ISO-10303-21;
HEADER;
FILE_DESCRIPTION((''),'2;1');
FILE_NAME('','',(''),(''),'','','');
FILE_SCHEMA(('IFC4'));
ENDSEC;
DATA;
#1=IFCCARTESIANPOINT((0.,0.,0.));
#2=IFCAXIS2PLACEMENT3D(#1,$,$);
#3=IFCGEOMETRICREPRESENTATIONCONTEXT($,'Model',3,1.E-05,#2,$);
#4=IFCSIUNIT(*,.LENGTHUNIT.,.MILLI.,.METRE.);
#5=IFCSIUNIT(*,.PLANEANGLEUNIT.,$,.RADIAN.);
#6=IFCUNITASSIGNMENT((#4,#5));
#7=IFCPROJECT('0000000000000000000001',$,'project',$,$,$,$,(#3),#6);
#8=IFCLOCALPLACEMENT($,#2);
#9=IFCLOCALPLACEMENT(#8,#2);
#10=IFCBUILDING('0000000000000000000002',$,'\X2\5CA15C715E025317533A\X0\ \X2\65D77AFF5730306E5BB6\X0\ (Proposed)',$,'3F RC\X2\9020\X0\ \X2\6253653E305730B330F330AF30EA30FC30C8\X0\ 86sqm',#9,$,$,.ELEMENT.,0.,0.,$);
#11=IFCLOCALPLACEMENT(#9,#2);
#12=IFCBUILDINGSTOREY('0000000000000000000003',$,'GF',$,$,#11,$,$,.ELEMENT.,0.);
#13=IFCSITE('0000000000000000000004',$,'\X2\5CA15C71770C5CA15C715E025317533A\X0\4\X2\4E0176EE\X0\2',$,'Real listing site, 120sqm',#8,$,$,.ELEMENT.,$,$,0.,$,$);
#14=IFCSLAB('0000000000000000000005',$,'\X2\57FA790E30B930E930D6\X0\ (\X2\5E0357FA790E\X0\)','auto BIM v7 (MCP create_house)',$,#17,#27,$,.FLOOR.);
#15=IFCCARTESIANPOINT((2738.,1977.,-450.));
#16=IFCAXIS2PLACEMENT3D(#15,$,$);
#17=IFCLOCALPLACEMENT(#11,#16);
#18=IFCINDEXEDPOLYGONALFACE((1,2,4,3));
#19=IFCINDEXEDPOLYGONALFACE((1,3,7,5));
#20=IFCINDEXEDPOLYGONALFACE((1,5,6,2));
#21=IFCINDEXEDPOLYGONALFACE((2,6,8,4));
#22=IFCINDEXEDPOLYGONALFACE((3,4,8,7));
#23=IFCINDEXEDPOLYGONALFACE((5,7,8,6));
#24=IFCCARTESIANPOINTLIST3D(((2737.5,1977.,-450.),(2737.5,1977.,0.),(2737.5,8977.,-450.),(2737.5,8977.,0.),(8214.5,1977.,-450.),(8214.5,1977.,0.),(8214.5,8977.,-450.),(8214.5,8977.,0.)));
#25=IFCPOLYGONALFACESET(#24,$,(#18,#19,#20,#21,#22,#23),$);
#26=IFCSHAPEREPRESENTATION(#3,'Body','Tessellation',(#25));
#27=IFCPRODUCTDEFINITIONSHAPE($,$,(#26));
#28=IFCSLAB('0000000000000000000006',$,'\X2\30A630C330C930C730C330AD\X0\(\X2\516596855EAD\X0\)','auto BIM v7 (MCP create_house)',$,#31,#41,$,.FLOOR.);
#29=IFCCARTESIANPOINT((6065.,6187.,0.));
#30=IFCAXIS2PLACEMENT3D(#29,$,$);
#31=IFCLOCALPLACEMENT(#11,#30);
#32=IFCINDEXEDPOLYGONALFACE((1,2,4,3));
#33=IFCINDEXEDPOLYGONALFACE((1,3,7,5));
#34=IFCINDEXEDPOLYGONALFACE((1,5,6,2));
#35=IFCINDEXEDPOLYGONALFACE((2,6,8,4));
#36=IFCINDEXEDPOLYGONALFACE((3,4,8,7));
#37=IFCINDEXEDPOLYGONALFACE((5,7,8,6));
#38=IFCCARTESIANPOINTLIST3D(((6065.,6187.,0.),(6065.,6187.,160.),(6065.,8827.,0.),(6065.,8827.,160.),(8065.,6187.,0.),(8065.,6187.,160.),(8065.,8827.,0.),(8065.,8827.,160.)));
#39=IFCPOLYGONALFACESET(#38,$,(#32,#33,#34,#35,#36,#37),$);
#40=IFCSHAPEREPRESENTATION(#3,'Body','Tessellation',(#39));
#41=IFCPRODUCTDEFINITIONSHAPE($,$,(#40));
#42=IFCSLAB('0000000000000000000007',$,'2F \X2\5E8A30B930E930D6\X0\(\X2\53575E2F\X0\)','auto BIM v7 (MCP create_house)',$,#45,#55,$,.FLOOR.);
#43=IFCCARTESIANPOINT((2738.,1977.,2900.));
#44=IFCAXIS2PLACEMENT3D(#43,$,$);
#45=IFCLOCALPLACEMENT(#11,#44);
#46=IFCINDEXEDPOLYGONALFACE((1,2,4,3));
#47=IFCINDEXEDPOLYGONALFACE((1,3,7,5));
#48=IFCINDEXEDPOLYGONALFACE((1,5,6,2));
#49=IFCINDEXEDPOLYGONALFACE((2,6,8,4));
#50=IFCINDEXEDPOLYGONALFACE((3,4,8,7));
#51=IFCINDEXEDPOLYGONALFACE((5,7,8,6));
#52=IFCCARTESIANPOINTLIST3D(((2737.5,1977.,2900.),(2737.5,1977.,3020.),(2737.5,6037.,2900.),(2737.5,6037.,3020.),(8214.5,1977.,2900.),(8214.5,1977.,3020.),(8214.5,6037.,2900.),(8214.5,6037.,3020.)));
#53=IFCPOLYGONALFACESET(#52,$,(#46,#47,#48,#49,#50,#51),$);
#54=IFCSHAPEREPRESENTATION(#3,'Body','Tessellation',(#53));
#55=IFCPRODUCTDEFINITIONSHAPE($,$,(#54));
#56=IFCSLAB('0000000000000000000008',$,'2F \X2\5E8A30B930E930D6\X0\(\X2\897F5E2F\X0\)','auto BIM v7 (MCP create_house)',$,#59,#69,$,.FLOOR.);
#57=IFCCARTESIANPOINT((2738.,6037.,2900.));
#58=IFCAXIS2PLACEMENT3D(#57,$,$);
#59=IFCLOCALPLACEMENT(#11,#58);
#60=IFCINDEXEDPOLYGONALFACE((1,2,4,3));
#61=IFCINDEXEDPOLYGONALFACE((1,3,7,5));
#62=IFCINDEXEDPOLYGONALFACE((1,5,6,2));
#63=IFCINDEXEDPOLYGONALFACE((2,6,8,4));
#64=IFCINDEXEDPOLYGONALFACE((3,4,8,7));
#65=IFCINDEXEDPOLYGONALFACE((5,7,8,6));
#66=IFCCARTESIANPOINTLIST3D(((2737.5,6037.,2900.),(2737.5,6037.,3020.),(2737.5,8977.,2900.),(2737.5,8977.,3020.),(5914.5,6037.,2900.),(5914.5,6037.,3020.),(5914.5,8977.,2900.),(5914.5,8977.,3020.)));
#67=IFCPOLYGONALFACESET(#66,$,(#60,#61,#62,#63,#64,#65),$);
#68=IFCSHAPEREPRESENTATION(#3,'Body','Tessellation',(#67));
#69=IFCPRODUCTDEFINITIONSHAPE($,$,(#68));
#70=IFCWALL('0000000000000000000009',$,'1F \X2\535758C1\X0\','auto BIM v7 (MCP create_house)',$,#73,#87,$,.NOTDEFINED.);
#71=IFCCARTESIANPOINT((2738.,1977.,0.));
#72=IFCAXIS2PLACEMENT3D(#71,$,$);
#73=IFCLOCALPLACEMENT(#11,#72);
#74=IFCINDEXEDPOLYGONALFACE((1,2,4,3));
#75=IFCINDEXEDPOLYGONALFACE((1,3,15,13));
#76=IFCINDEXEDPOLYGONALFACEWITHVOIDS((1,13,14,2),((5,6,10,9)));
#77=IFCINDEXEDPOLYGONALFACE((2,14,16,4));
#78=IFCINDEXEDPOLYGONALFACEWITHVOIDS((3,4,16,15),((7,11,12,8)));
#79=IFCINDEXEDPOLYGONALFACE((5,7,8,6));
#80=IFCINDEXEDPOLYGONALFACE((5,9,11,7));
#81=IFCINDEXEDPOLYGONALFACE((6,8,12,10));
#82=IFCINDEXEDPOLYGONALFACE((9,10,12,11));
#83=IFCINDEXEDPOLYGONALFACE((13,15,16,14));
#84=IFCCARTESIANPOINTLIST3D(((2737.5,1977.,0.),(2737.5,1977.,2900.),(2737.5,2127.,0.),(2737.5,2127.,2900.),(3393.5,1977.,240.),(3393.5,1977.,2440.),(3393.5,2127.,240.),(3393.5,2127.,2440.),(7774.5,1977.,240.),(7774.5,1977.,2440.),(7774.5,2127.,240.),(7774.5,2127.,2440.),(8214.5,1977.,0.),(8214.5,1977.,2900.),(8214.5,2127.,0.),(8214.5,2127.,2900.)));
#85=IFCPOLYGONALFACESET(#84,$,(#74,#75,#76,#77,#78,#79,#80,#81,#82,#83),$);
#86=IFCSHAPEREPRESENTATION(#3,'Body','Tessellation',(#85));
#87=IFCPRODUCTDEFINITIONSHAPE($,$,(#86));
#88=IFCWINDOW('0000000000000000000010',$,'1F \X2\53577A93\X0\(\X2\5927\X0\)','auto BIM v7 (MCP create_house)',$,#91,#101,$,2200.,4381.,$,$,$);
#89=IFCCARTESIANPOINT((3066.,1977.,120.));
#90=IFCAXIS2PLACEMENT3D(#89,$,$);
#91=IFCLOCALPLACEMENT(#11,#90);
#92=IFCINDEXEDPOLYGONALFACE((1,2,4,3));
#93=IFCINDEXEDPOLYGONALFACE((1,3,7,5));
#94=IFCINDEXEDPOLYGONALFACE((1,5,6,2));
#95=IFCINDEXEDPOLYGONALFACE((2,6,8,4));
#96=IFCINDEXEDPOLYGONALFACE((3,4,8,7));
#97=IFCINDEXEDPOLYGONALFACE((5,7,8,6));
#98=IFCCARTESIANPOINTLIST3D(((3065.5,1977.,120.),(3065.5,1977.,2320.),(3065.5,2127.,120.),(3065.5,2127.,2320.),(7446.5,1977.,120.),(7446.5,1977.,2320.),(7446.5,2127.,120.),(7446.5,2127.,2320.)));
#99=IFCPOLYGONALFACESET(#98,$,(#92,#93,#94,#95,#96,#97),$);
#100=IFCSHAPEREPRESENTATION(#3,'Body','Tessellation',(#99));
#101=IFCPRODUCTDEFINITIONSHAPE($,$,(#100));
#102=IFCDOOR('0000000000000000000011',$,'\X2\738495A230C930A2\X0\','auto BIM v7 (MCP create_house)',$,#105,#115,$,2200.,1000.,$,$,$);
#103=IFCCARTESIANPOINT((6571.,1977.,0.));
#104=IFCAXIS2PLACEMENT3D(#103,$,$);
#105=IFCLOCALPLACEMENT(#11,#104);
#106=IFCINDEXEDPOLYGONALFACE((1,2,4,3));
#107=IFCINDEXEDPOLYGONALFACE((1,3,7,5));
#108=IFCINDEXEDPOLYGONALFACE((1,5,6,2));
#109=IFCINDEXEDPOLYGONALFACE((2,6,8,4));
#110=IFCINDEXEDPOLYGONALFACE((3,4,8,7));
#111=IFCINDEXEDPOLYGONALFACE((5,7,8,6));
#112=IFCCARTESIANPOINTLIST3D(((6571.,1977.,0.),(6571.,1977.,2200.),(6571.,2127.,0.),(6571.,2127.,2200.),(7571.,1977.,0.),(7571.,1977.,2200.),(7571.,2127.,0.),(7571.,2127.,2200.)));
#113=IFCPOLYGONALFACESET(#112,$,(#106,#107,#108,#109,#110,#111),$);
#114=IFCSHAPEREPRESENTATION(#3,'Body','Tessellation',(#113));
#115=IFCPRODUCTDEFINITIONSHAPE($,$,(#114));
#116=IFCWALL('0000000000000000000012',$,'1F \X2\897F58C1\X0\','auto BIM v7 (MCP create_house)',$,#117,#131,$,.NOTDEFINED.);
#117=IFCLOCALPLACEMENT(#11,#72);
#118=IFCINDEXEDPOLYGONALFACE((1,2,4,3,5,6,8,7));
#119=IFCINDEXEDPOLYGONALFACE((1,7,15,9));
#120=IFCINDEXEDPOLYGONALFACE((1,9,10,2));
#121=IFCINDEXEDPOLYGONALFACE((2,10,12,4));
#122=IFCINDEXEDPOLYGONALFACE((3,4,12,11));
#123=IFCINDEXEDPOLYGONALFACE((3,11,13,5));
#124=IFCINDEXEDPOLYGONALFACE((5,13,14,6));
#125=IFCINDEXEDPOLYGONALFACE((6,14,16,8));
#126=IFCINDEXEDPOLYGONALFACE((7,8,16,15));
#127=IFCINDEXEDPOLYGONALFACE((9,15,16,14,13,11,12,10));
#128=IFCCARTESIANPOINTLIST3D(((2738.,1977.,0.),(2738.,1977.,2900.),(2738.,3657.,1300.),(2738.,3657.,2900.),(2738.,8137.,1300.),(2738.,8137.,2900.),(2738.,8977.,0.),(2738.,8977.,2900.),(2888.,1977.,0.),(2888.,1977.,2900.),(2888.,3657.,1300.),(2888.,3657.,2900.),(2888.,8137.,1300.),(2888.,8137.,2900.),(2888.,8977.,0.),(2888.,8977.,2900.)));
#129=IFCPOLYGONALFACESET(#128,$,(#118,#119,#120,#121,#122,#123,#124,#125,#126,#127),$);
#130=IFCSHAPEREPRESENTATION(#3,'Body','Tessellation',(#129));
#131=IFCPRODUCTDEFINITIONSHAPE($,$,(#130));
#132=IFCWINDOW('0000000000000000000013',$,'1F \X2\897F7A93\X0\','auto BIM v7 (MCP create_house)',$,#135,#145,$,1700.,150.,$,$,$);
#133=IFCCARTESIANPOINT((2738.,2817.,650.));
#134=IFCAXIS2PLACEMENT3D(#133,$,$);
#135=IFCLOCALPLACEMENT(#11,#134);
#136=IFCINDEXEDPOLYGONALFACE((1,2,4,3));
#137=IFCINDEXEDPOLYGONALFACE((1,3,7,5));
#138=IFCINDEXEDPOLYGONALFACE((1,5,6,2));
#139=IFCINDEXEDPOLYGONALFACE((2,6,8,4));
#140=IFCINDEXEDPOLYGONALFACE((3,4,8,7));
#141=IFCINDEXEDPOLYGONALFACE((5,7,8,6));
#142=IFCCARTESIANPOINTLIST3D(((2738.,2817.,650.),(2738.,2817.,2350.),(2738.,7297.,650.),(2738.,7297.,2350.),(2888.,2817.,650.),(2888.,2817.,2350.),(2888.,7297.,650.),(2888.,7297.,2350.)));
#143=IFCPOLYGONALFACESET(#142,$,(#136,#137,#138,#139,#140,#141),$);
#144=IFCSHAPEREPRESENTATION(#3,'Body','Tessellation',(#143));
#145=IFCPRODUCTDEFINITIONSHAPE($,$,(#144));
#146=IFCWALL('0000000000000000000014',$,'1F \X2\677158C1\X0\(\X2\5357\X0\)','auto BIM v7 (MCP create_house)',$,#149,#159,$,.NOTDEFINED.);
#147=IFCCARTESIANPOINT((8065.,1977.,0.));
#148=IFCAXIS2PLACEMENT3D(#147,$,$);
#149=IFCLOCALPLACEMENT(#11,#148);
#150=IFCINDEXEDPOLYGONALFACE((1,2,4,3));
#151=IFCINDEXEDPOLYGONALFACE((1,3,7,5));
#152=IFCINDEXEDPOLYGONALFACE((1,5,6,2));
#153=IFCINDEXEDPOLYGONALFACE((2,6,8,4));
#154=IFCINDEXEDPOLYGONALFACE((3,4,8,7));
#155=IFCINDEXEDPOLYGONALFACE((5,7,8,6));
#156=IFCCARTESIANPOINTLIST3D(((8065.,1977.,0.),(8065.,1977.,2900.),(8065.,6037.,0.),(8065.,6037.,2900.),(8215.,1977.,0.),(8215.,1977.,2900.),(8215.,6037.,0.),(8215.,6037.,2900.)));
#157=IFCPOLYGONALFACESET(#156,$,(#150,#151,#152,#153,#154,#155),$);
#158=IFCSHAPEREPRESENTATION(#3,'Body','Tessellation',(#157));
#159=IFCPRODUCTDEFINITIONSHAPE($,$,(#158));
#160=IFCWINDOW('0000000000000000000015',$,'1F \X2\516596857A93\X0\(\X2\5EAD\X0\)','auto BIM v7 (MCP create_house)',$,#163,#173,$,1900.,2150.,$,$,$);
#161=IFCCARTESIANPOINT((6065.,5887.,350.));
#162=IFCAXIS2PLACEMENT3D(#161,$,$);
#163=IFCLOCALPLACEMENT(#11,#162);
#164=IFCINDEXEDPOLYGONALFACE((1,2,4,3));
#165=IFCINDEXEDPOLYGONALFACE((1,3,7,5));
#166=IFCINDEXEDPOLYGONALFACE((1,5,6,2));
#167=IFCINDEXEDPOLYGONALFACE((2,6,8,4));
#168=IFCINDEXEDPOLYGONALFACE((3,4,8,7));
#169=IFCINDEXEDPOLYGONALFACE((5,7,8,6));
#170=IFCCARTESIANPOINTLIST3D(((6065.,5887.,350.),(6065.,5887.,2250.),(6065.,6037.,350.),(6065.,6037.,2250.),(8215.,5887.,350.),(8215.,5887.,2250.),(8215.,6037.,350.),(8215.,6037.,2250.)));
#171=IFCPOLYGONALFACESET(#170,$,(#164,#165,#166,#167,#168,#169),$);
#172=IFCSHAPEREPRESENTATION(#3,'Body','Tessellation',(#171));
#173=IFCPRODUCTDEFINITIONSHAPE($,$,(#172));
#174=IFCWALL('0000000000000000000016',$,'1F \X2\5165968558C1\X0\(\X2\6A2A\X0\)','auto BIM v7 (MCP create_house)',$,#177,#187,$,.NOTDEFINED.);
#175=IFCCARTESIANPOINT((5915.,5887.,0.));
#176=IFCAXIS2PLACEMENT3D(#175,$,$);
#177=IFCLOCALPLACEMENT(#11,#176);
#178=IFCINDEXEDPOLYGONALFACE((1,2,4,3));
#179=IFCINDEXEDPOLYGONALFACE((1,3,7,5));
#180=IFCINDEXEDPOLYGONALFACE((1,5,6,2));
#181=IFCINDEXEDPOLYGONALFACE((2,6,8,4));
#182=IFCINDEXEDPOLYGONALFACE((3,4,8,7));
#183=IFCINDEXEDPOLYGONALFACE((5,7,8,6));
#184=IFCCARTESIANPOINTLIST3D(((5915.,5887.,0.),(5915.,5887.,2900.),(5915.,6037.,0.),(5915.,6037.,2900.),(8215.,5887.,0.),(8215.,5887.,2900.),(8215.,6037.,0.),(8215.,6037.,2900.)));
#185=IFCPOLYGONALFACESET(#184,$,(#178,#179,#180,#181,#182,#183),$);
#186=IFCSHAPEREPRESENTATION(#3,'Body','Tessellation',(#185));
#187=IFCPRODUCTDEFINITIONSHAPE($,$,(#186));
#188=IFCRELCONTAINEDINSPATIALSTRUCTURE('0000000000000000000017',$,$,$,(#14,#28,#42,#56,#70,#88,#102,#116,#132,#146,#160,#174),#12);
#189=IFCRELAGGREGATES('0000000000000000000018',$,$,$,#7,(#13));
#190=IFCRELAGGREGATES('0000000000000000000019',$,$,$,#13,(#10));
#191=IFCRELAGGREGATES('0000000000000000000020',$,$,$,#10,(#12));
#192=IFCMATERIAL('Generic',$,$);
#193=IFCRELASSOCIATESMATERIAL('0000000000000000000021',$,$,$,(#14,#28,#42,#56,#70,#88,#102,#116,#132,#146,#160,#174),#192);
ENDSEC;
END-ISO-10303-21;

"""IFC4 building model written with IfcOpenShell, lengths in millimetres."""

from ifc_helpers import new_model, si_unit, frame, frame_2d, origin, place, context, project, spatial, rectangle, extrude, material, element, fill, save


model = new_model("IFC4")

# Units and contexts
model_context = context("Model", 3, precision=1e-05, world=origin())
ifc_project = project(units=[si_unit("LENGTHUNIT", "METRE", prefix="MILLI"), si_unit("PLANEANGLEUNIT", "RADIAN")], contexts=[model_context])

# Site, building, storey
site_placement = place(None, origin())
site = spatial("IfcSite", under=ifc_project, at=site_placement, Name="岡山県岡山市北区4丁目2", ObjectType="Real listing site, 120sqm", CompositionType="ELEMENT", RefElevation=0.0)
building_placement = place(site_placement, origin())
building = spatial("IfcBuilding", under=site, at=building_placement, Name="岡山市北区 旗竿地の家 (Proposed)", ObjectType="3F RC造 打放しコンクリート 86sqm", CompositionType="ELEMENT", ElevationOfRefHeight=0.0, ElevationOfTerrain=0.0)
storey_placement = place(building_placement, origin())
storey = spatial("IfcBuildingStorey", under=building, at=storey_placement, Name="GF", CompositionType="ELEMENT", Elevation=0.0)

# Slabs
ifc_material = material(Name="Generic")
slab_1_placement = place(storey_placement, frame((2738.0, 1977.0, -450.0)))
element("IfcSlab", 1, at=slab_1_placement, inside=storey, material=ifc_material, Name="基礎スラブ (布基礎)", Description="auto BIM v7 (MCP create_house)", PredefinedType="FLOOR", context=model_context, shape_type="SweptSolid", body=[
    extrude(rectangle(XDim=5477.0, YDim=7000.0, at=frame_2d((2738.0, 3500.0))), frame((2738.0, 1977.0, -450.0)), (0.0, 0.0, 1.0), 450.0),
])
slab_2_placement = place(storey_placement, frame((6065.0, 6187.0, 0.0)))
element("IfcSlab", 2, at=slab_2_placement, inside=storey, material=ifc_material, Name="ウッドデッキ(入隅庭)", Description="auto BIM v7 (MCP create_house)", PredefinedType="FLOOR", context=model_context, shape_type="SweptSolid", body=[
    extrude(rectangle(XDim=2000.0, YDim=2640.0, at=frame_2d((1000.0, 1320.0))), frame((6065.0, 6187.0, 0.0)), (0.0, 0.0, 1.0), 160.0),
])
slab_3_placement = place(storey_placement, frame((2738.0, 1977.0, 2900.0)))
element("IfcSlab", 3, at=slab_3_placement, inside=storey, material=ifc_material, Name="2F 床スラブ(南帯)", Description="auto BIM v7 (MCP create_house)", PredefinedType="FLOOR", context=model_context, shape_type="SweptSolid", body=[
    extrude(rectangle(XDim=5477.0, YDim=4060.0, at=frame_2d((2738.0, 2030.0))), frame((2738.0, 1977.0, 2900.0)), (0.0, 0.0, 1.0), 120.0),
])
slab_4_placement = place(storey_placement, frame((2738.0, 6037.0, 2900.0)))
element("IfcSlab", 4, at=slab_4_placement, inside=storey, material=ifc_material, Name="2F 床スラブ(西帯)", Description="auto BIM v7 (MCP create_house)", PredefinedType="FLOOR", context=model_context, shape_type="SweptSolid", body=[
    extrude(rectangle(XDim=3177.0, YDim=2940.0, at=frame_2d((1588.0, 1470.0))), frame((2738.0, 6037.0, 2900.0)), (0.0, 0.0, 1.0), 120.0),
])

# Wall, openings, window, door
wall_1_placement = place(storey_placement, frame((2738.0, 1977.0, 0.0)))
wall_1 = element("IfcWall", 5, at=wall_1_placement, inside=storey, material=ifc_material, Name="1F 南壁", Description="auto BIM v7 (MCP create_house)", PredefinedType="NOTDEFINED", context=model_context, shape_type="SweptSolid", body=[
    extrude(rectangle(XDim=5477.0, YDim=150.0, at=frame_2d((2738.0, 75.0))), frame((2738.0, 1977.0, 0.0)), (0.0, 0.0, 1.0), 2900.0),
])
opening_1_placement = place(storey_placement, frame((3066.0, 1977.0, 120.0)))
opening_1 = element("IfcOpeningElement", 6, at=opening_1_placement, cuts=wall_1, PredefinedType="NOTDEFINED", context=model_context, shape_type="SweptSolid", body=[
    extrude(rectangle(XDim=4381.0, YDim=150.0, at=frame_2d((2190.0, 75.0))), frame((3066.0, 1977.0, 120.0)), (0.0, 0.0, 1.0), 2200.0),
])
opening_2_placement = place(storey_placement, frame((6571.0, 1977.0, 0.0)))
opening_2 = element("IfcOpeningElement", 7, at=opening_2_placement, cuts=wall_1, PredefinedType="NOTDEFINED", context=model_context, shape_type="SweptSolid", body=[
    extrude(rectangle(XDim=1000.0, YDim=150.0, at=frame_2d((500.0, 75.0))), frame((6571.0, 1977.0, 0.0)), (0.0, 0.0, 1.0), 2200.0),
])
window_1_placement = place(storey_placement, frame((3066.0, 1977.0, 120.0)))
window_1 = element("IfcWindow", 8, at=window_1_placement, inside=storey, material=ifc_material, Name="1F 南窓(大)", Description="auto BIM v7 (MCP create_house)", OverallHeight=2200.0, OverallWidth=4381.0, context=model_context, shape_type="SweptSolid", body=[
    extrude(rectangle(XDim=4381.0, YDim=150.0, at=frame_2d((2190.0, 75.0))), frame((3066.0, 1977.0, 120.0)), (0.0, 0.0, 1.0), 2200.0),
])
fill(opening_1, window_1)
door_placement = place(storey_placement, frame((6571.0, 1977.0, 0.0)))
door = element("IfcDoor", 9, at=door_placement, inside=storey, material=ifc_material, Name="玄関ドア", Description="auto BIM v7 (MCP create_house)", OverallHeight=2200.0, OverallWidth=1000.0, context=model_context, shape_type="SweptSolid", body=[
    extrude(rectangle(XDim=1000.0, YDim=150.0, at=frame_2d((500.0, 75.0))), frame((6571.0, 1977.0, 0.0)), (0.0, 0.0, 1.0), 2200.0),
])
fill(opening_2, door)

# Wall, opening, window
wall_2_placement = place(storey_placement, frame((2738.0, 1977.0, 0.0)))
wall_2 = element("IfcWall", 10, at=wall_2_placement, inside=storey, material=ifc_material, Name="1F 西壁", Description="auto BIM v7 (MCP create_house)", PredefinedType="NOTDEFINED", context=model_context, shape_type="SweptSolid", body=[
    extrude(rectangle(XDim=150.0, YDim=7000.0, at=frame_2d((75.0, 3500.0))), frame((2738.0, 1977.0, 0.0)), (0.0, 0.0, 1.0), 2900.0),
])
opening_3_placement = place(storey_placement, frame((2738.0, 2817.0, 650.0)))
opening_3 = element("IfcOpeningElement", 11, at=opening_3_placement, cuts=wall_2, PredefinedType="NOTDEFINED", context=model_context, shape_type="SweptSolid", body=[
    extrude(rectangle(XDim=150.0, YDim=4480.0, at=frame_2d((75.0, 2240.0))), frame((2738.0, 2817.0, 650.0)), (0.0, 0.0, 1.0), 1700.0),
])
window_2_placement = place(storey_placement, frame((2738.0, 2817.0, 650.0)))
window_2 = element("IfcWindow", 12, at=window_2_placement, inside=storey, material=ifc_material, Name="1F 西窓", Description="auto BIM v7 (MCP create_house)", OverallHeight=1700.0, OverallWidth=150.0, context=model_context, shape_type="SweptSolid", body=[
    extrude(rectangle(XDim=150.0, YDim=4480.0, at=frame_2d((75.0, 2240.0))), frame((2738.0, 2817.0, 650.0)), (0.0, 0.0, 1.0), 1700.0),
])
fill(opening_3, window_2)

# Wall, opening, window
wall_3_placement = place(storey_placement, frame((8065.0, 1977.0, 0.0)))
wall_3 = element("IfcWall", 13, at=wall_3_placement, inside=storey, material=ifc_material, Name="1F 東壁(南)", Description="auto BIM v7 (MCP create_house)", PredefinedType="NOTDEFINED", context=model_context, shape_type="SweptSolid", body=[
    extrude(rectangle(XDim=150.0, YDim=4060.0, at=frame_2d((75.0, 2030.0))), frame((8065.0, 1977.0, 0.0)), (0.0, 0.0, 1.0), 2900.0),
])
opening_4_placement = place(storey_placement, frame((6065.0, 5887.0, 350.0)))
opening_4 = element("IfcOpeningElement", 14, at=opening_4_placement, cuts=wall_3, PredefinedType="NOTDEFINED", context=model_context, shape_type="SweptSolid", body=[
    extrude(rectangle(XDim=2150.0, YDim=150.0, at=frame_2d((1075.0, 75.0))), frame((6065.0, 5887.0, 350.0)), (0.0, 0.0, 1.0), 1900.0),
])
window_3_placement = place(storey_placement, frame((6065.0, 5887.0, 350.0)))
window_3 = element("IfcWindow", 15, at=window_3_placement, inside=storey, material=ifc_material, Name="1F 入隅窓(庭)", Description="auto BIM v7 (MCP create_house)", OverallHeight=1900.0, OverallWidth=2150.0, context=model_context, shape_type="SweptSolid", body=[
    extrude(rectangle(XDim=2150.0, YDim=150.0, at=frame_2d((1075.0, 75.0))), frame((6065.0, 5887.0, 350.0)), (0.0, 0.0, 1.0), 1900.0),
])
fill(opening_4, window_3)

# Wall
wall_4_placement = place(storey_placement, frame((5915.0, 5887.0, 0.0)))
element("IfcWall", 16, at=wall_4_placement, inside=storey, material=ifc_material, Name="1F 入隅壁(横)", Description="auto BIM v7 (MCP create_house)", PredefinedType="NOTDEFINED", context=model_context, shape_type="SweptSolid", body=[
    extrude(rectangle(XDim=2300.0, YDim=150.0, at=frame_2d((1150.0, 75.0))), frame((5915.0, 5887.0, 0.0)), (0.0, 0.0, 1.0), 2900.0),
])

save(model, "model.ifc")
